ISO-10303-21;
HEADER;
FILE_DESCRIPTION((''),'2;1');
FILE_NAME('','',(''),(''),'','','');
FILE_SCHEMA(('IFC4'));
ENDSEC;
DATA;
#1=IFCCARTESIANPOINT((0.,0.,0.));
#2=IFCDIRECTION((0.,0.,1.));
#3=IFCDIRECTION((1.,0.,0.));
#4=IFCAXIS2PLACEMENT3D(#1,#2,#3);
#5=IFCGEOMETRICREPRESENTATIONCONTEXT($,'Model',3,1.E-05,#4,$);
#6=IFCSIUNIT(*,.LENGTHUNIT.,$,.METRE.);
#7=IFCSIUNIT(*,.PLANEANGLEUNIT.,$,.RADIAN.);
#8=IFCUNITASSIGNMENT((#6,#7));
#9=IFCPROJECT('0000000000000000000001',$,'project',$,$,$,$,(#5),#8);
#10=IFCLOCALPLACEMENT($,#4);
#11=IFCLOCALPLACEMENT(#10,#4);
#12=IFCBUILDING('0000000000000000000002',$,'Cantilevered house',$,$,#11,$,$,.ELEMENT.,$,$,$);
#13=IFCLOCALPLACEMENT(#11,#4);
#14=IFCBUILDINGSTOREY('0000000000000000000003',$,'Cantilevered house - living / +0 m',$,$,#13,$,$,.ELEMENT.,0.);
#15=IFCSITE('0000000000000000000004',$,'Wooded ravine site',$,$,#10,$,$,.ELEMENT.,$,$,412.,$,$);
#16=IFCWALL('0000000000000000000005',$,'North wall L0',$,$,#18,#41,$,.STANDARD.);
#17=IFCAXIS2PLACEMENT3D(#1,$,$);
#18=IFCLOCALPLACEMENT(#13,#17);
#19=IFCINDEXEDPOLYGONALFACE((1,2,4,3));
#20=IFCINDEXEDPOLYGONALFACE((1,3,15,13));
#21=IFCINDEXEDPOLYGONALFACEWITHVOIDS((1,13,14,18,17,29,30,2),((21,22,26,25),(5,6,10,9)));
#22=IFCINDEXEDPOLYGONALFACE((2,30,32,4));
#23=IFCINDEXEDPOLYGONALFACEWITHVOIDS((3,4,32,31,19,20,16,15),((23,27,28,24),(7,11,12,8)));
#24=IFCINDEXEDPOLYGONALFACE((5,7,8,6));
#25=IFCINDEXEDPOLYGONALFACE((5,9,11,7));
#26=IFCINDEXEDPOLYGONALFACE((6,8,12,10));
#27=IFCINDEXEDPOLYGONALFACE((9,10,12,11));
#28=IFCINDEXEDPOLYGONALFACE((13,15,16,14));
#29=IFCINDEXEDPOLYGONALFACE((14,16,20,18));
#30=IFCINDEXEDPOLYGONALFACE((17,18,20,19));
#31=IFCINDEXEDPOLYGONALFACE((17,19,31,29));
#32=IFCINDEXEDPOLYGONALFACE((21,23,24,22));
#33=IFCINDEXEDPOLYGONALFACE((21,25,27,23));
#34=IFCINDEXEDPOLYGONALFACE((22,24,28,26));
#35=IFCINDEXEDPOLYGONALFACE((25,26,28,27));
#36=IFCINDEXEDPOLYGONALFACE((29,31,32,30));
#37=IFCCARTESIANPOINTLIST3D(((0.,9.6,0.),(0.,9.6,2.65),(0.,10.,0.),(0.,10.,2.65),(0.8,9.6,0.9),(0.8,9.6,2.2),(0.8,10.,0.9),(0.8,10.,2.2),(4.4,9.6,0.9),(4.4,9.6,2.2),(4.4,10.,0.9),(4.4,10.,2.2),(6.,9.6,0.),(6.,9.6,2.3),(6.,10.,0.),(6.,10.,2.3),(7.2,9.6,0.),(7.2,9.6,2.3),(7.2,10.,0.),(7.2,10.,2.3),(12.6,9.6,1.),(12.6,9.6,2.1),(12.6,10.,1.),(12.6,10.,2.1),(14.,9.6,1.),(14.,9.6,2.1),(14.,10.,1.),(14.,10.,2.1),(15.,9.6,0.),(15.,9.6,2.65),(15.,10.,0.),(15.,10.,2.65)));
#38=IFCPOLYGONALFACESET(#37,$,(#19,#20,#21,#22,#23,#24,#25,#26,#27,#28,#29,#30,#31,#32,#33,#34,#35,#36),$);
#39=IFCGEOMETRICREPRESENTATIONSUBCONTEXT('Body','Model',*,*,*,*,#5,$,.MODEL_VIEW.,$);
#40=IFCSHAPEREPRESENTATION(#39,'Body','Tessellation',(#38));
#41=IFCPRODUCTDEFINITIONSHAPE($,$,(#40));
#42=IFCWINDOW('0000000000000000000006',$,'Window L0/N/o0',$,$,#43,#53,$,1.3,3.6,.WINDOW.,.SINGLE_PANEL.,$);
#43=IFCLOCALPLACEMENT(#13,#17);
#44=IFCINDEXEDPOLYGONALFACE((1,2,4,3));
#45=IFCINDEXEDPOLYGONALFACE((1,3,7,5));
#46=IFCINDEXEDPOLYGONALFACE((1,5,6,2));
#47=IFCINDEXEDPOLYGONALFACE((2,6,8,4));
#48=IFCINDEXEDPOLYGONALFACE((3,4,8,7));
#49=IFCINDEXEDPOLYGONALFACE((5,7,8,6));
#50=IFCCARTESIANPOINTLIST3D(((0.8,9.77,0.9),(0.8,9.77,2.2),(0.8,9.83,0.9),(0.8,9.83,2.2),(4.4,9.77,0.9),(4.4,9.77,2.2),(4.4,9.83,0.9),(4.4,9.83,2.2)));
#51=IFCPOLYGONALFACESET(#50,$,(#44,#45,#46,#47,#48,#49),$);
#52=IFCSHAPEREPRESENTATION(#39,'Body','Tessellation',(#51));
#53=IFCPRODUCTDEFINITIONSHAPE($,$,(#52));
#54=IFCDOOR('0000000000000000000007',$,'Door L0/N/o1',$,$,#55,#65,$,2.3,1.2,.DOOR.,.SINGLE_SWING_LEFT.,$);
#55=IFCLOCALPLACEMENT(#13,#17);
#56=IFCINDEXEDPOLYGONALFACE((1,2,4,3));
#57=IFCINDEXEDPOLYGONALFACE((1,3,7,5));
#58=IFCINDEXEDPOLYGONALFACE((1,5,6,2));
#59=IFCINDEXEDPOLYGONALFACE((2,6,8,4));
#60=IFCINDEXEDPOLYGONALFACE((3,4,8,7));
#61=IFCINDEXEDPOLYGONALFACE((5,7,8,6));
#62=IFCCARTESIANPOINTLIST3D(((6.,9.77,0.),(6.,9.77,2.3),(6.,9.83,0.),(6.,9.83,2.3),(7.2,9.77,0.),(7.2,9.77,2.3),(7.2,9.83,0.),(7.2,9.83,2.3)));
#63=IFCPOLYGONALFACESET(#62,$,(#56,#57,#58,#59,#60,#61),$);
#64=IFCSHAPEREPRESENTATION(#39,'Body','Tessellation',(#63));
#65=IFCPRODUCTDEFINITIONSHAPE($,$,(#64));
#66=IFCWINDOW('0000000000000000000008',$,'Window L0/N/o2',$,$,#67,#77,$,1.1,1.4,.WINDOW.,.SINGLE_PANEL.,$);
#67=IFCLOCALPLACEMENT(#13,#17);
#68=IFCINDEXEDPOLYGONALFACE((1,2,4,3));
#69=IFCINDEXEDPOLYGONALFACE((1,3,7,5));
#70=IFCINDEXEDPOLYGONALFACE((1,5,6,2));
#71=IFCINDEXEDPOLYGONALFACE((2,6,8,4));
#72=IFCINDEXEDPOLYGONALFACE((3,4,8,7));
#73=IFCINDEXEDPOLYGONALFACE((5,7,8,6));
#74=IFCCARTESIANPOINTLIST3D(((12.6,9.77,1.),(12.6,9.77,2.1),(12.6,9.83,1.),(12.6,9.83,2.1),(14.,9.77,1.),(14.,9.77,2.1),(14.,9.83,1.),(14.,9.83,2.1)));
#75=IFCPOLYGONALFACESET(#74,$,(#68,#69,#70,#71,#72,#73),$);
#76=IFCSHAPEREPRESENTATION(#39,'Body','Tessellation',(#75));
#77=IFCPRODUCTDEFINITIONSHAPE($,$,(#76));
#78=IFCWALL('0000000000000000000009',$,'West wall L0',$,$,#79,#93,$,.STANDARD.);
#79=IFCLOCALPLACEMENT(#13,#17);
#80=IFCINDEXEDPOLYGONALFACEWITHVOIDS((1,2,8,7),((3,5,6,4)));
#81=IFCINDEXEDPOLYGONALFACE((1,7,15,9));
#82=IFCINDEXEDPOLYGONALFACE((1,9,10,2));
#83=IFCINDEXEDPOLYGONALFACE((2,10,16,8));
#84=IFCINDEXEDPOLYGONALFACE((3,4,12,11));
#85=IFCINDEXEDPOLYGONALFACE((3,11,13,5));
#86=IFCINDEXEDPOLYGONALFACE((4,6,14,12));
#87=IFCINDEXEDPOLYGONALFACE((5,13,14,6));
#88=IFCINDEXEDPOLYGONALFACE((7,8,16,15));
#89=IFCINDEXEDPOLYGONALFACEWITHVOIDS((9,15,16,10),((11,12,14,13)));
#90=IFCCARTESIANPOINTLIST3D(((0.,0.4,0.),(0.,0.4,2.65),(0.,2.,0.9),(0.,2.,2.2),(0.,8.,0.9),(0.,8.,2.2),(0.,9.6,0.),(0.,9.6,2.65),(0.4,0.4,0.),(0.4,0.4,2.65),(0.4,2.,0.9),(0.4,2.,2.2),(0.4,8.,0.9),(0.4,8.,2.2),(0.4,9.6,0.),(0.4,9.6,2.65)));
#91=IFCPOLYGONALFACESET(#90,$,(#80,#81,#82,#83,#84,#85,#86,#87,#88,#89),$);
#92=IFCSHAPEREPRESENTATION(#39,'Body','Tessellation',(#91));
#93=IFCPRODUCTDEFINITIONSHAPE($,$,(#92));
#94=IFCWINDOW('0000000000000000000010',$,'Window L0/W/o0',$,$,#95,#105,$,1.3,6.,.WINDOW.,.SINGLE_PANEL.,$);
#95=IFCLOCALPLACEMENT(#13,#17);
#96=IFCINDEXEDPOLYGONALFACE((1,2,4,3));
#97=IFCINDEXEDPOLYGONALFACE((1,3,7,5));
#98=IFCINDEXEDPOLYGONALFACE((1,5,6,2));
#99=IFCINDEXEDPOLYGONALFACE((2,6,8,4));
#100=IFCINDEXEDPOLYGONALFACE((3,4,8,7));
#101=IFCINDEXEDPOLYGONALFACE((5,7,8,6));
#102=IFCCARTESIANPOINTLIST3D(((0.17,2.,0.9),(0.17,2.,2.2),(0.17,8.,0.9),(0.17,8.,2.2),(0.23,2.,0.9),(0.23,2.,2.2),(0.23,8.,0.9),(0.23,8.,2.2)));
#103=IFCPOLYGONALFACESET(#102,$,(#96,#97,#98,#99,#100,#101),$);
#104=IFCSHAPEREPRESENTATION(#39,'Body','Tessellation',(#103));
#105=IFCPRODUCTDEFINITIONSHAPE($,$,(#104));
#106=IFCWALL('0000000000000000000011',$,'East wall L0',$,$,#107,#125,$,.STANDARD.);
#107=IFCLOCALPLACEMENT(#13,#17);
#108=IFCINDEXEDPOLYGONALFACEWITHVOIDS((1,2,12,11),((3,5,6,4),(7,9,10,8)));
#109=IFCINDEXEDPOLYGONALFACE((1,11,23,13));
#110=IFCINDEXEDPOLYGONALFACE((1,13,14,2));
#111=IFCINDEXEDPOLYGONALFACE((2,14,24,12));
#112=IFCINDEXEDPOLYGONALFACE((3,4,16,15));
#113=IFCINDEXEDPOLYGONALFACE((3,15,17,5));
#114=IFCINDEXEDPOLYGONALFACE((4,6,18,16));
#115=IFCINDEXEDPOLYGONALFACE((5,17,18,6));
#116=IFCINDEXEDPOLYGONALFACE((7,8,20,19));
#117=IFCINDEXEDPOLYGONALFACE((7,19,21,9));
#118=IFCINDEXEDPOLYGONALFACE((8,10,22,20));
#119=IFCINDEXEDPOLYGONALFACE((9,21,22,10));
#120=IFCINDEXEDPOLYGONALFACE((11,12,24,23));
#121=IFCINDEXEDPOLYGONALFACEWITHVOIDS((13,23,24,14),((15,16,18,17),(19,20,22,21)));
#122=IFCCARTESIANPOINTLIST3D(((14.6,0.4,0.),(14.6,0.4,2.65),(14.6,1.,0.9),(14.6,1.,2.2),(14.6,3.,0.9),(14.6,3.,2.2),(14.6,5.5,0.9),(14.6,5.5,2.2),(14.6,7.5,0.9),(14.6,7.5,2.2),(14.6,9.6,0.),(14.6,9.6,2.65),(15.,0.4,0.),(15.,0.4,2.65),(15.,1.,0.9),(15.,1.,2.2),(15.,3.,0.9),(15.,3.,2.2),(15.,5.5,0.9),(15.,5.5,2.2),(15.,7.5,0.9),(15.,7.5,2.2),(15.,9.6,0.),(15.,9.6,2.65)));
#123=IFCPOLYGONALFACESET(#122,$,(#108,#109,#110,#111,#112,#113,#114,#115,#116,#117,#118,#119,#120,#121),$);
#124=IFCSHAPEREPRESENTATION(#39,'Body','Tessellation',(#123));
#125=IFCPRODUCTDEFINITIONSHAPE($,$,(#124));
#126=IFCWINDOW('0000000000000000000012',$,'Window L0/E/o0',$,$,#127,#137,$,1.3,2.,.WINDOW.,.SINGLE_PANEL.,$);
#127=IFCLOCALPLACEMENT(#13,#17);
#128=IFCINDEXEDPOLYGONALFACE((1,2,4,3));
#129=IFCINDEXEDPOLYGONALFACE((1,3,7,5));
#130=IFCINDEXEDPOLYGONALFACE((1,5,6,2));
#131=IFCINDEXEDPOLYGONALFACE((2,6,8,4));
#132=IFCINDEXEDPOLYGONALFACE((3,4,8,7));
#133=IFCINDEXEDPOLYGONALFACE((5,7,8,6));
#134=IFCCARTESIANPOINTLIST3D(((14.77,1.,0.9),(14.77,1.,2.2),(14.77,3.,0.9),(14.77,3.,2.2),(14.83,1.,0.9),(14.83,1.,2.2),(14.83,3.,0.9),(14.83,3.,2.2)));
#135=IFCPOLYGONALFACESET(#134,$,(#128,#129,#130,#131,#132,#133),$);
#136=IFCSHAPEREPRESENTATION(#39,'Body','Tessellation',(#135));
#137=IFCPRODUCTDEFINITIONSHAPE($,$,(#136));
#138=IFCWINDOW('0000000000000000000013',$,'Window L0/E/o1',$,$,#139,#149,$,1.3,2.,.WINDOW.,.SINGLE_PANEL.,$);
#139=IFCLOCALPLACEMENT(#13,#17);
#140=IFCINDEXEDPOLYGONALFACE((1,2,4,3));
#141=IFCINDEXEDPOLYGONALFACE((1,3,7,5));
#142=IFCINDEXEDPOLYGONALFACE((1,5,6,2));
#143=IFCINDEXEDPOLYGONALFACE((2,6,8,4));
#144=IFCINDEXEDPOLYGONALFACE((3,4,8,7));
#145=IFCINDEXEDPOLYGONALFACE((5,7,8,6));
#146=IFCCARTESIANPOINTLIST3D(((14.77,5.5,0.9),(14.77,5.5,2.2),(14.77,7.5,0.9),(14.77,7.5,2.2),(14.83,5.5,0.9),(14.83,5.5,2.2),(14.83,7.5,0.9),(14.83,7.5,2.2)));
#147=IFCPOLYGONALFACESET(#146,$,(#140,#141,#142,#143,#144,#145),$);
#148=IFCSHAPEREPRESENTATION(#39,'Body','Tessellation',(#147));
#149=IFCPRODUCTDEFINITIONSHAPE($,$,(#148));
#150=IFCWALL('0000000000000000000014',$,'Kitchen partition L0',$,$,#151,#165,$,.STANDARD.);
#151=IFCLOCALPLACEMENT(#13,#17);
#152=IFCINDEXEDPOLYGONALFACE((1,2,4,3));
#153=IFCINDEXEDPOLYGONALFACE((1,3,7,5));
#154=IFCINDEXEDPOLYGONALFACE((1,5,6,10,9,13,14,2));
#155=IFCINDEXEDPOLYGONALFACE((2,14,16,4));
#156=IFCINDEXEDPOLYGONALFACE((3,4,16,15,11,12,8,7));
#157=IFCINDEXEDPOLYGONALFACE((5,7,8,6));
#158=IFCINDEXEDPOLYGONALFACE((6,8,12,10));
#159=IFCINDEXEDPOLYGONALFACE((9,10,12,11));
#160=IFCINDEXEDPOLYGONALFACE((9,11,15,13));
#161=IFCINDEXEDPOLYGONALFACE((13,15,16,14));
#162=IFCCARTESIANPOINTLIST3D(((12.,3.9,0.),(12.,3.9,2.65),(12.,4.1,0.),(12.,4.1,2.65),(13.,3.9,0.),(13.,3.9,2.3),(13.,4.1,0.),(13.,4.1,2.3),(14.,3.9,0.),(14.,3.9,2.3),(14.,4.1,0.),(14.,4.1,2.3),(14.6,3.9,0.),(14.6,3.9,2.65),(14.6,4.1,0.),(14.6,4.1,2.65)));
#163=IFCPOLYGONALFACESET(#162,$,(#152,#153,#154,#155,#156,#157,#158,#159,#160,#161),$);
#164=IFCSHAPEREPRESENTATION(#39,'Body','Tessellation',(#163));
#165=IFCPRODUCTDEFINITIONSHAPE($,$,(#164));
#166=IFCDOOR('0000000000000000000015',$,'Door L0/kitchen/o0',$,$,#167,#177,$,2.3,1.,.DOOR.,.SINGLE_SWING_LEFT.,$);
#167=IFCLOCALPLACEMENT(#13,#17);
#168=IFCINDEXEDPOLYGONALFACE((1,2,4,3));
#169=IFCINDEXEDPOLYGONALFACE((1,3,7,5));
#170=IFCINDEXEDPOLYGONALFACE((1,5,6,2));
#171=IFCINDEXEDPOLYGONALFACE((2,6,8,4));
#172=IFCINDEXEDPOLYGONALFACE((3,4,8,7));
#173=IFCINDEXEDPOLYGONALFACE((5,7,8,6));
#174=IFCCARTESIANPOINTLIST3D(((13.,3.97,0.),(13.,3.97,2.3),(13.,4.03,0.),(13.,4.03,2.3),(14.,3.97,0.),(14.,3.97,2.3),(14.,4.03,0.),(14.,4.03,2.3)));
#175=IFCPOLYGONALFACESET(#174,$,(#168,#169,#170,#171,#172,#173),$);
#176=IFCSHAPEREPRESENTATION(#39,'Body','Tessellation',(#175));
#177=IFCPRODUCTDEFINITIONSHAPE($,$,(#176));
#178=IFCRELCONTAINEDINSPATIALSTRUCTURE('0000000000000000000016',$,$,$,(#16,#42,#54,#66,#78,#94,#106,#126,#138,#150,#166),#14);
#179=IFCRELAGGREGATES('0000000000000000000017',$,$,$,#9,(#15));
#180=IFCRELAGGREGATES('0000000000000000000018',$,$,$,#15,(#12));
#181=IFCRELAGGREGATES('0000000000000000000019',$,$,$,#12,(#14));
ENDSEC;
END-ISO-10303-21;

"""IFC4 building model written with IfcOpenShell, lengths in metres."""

from ifc_helpers import new_model, si_unit, frame, frame_2d, origin_with_axes, place, context, subcontext, project, spatial, rectangle, extrude, element, fill, save


model = new_model("IFC4")

# Units and contexts
model_context = context("Model", 3, precision=1e-05, world=origin_with_axes())
body_context = subcontext(model_context, "Body", "Model", "MODEL_VIEW")
ifc_project = project(units=[si_unit("LENGTHUNIT", "METRE"), si_unit("PLANEANGLEUNIT", "RADIAN")], contexts=[model_context])

# Site, building, storey
site_placement = place(None, origin_with_axes())
site = spatial("IfcSite", under=ifc_project, at=site_placement, Name="Wooded ravine site", CompositionType="ELEMENT", RefElevation=412.0)
building_placement = place(site_placement, origin_with_axes())
building = spatial("IfcBuilding", under=site, at=building_placement, Name="Cantilevered house", CompositionType="ELEMENT")
storey_placement = place(building_placement, origin_with_axes())
storey = spatial("IfcBuildingStorey", under=building, at=storey_placement, Name="Cantilevered house - living / +0 m", CompositionType="ELEMENT", Elevation=0.0)

# Wall, openings, windows, door
wall_1_placement = place(storey_placement, origin_with_axes())
wall_1 = element("IfcWall", 1, at=wall_1_placement, inside=storey, Name="North wall L0", PredefinedType="STANDARD", context=body_context, shape_type="SweptSolid", body=[
    extrude(rectangle(XDim=15.0, YDim=0.4, at=frame_2d((7.5, 9.8))), origin_with_axes(), (0.0, 0.0, 1.0), 2.65),
])
opening_1_placement = place(storey_placement, origin_with_axes())
opening_1 = element("IfcOpeningElement", 2, at=opening_1_placement, inside=storey, cuts=wall_1, PredefinedType="OPENING", context=body_context, shape_type="SweptSolid", body=[
    extrude(rectangle(XDim=3.6, YDim=0.44, at=frame_2d((2.6, 9.8))), frame((0.0, 0.0, 0.9), z_axis=(0.0, 0.0, 1.0), x_axis=(1.0, 0.0, 0.0)), (0.0, 0.0, 1.0), 1.3),
])
opening_2_placement = place(storey_placement, origin_with_axes())
opening_2 = element("IfcOpeningElement", 3, at=opening_2_placement, inside=storey, cuts=wall_1, PredefinedType="OPENING", context=body_context, shape_type="SweptSolid", body=[
    extrude(rectangle(XDim=1.2, YDim=0.44, at=frame_2d((6.6, 9.8))), origin_with_axes(), (0.0, 0.0, 1.0), 2.3),
])
opening_3_placement = place(storey_placement, origin_with_axes())
opening_3 = element("IfcOpeningElement", 4, at=opening_3_placement, inside=storey, cuts=wall_1, PredefinedType="OPENING", context=body_context, shape_type="SweptSolid", body=[
    extrude(rectangle(XDim=1.4, YDim=0.44, at=frame_2d((13.3, 9.8))), frame((0.0, 0.0, 1.0), z_axis=(0.0, 0.0, 1.0), x_axis=(1.0, 0.0, 0.0)), (0.0, 0.0, 1.0), 1.1),
])
window_1_placement = place(storey_placement, origin_with_axes())
window_1 = element("IfcWindow", 5, at=window_1_placement, inside=storey, Name="Window L0/N/o0", OverallHeight=1.3, OverallWidth=3.6, PartitioningType="SINGLE_PANEL", PredefinedType="WINDOW", context=body_context, shape_type="SweptSolid", body=[
    extrude(rectangle(XDim=3.6, YDim=0.06, at=frame_2d((2.6, 9.8))), frame((0.0, 0.0, 0.9), z_axis=(0.0, 0.0, 1.0), x_axis=(1.0, 0.0, 0.0)), (0.0, 0.0, 1.0), 1.3),
])
fill(opening_1, window_1)
door_1_placement = place(storey_placement, origin_with_axes())
door_1 = element("IfcDoor", 6, at=door_1_placement, inside=storey, Name="Door L0/N/o1", OperationType="SINGLE_SWING_LEFT", OverallHeight=2.3, OverallWidth=1.2, PredefinedType="DOOR", context=body_context, shape_type="SweptSolid", body=[
    extrude(rectangle(XDim=1.2, YDim=0.06, at=frame_2d((6.6, 9.8))), origin_with_axes(), (0.0, 0.0, 1.0), 2.3),
])
fill(opening_2, door_1)
window_2_placement = place(storey_placement, origin_with_axes())
window_2 = element("IfcWindow", 7, at=window_2_placement, inside=storey, Name="Window L0/N/o2", OverallHeight=1.1, OverallWidth=1.4, PartitioningType="SINGLE_PANEL", PredefinedType="WINDOW", context=body_context, shape_type="SweptSolid", body=[
    extrude(rectangle(XDim=1.4, YDim=0.06, at=frame_2d((13.3, 9.8))), frame((0.0, 0.0, 1.0), z_axis=(0.0, 0.0, 1.0), x_axis=(1.0, 0.0, 0.0)), (0.0, 0.0, 1.0), 1.1),
])
fill(opening_3, window_2)

# Wall, opening, window
wall_2_placement = place(storey_placement, origin_with_axes())
wall_2 = element("IfcWall", 8, at=wall_2_placement, inside=storey, Name="West wall L0", PredefinedType="STANDARD", context=body_context, shape_type="SweptSolid", body=[
    extrude(rectangle(XDim=0.4, YDim=9.2, at=frame_2d((0.2, 5.0))), origin_with_axes(), (0.0, 0.0, 1.0), 2.65),
])
opening_4_placement = place(storey_placement, origin_with_axes())
opening_4 = element("IfcOpeningElement", 9, at=opening_4_placement, inside=storey, cuts=wall_2, PredefinedType="OPENING", context=body_context, shape_type="SweptSolid", body=[
    extrude(rectangle(XDim=0.44, YDim=6.0, at=frame_2d((0.2, 5.0))), frame((0.0, 0.0, 0.9), z_axis=(0.0, 0.0, 1.0), x_axis=(1.0, 0.0, 0.0)), (0.0, 0.0, 1.0), 1.3),
])
window_3_placement = place(storey_placement, origin_with_axes())
window_3 = element("IfcWindow", 10, at=window_3_placement, inside=storey, Name="Window L0/W/o0", OverallHeight=1.3, OverallWidth=6.0, PartitioningType="SINGLE_PANEL", PredefinedType="WINDOW", context=body_context, shape_type="SweptSolid", body=[
    extrude(rectangle(XDim=0.06, YDim=6.0, at=frame_2d((0.2, 5.0))), frame((0.0, 0.0, 0.9), z_axis=(0.0, 0.0, 1.0), x_axis=(1.0, 0.0, 0.0)), (0.0, 0.0, 1.0), 1.3),
])
fill(opening_4, window_3)

# Wall, openings, windows
wall_3_placement = place(storey_placement, origin_with_axes())
wall_3 = element("IfcWall", 11, at=wall_3_placement, inside=storey, Name="East wall L0", PredefinedType="STANDARD", context=body_context, shape_type="SweptSolid", body=[
    extrude(rectangle(XDim=0.4, YDim=9.2, at=frame_2d((14.8, 5.0))), origin_with_axes(), (0.0, 0.0, 1.0), 2.65),
])
opening_5_placement = place(storey_placement, origin_with_axes())
opening_5 = element("IfcOpeningElement", 12, at=opening_5_placement, inside=storey, cuts=wall_3, PredefinedType="OPENING", context=body_context, shape_type="SweptSolid", body=[
    extrude(rectangle(XDim=0.44, YDim=2.0, at=frame_2d((14.8, 2.0))), frame((0.0, 0.0, 0.9), z_axis=(0.0, 0.0, 1.0), x_axis=(1.0, 0.0, 0.0)), (0.0, 0.0, 1.0), 1.3),
])
opening_6_placement = place(storey_placement, origin_with_axes())
opening_6 = element("IfcOpeningElement", 13, at=opening_6_placement, inside=storey, cuts=wall_3, PredefinedType="OPENING", context=body_context, shape_type="SweptSolid", body=[
    extrude(rectangle(XDim=0.44, YDim=2.0, at=frame_2d((14.8, 6.5))), frame((0.0, 0.0, 0.9), z_axis=(0.0, 0.0, 1.0), x_axis=(1.0, 0.0, 0.0)), (0.0, 0.0, 1.0), 1.3),
])
window_4_placement = place(storey_placement, origin_with_axes())
window_4 = element("IfcWindow", 14, at=window_4_placement, inside=storey, Name="Window L0/E/o0", OverallHeight=1.3, OverallWidth=2.0, PartitioningType="SINGLE_PANEL", PredefinedType="WINDOW", context=body_context, shape_type="SweptSolid", body=[
    extrude(rectangle(XDim=0.06, YDim=2.0, at=frame_2d((14.8, 2.0))), frame((0.0, 0.0, 0.9), z_axis=(0.0, 0.0, 1.0), x_axis=(1.0, 0.0, 0.0)), (0.0, 0.0, 1.0), 1.3),
])
fill(opening_5, window_4)
window_5_placement = place(storey_placement, origin_with_axes())
window_5 = element("IfcWindow", 15, at=window_5_placement, inside=storey, Name="Window L0/E/o1", OverallHeight=1.3, OverallWidth=2.0, PartitioningType="SINGLE_PANEL", PredefinedType="WINDOW", context=body_context, shape_type="SweptSolid", body=[
    extrude(rectangle(XDim=0.06, YDim=2.0, at=frame_2d((14.8, 6.5))), frame((0.0, 0.0, 0.9), z_axis=(0.0, 0.0, 1.0), x_axis=(1.0, 0.0, 0.0)), (0.0, 0.0, 1.0), 1.3),
])
fill(opening_6, window_5)

# Wall, opening, door
wall_4_placement = place(storey_placement, origin_with_axes())
wall_4 = element("IfcWall", 16, at=wall_4_placement, inside=storey, Name="Kitchen partition L0", PredefinedType="STANDARD", context=body_context, shape_type="SweptSolid", body=[
    extrude(rectangle(XDim=2.6, YDim=0.2, at=frame_2d((13.3, 4.0))), origin_with_axes(), (0.0, 0.0, 1.0), 2.65),
])
opening_7_placement = place(storey_placement, origin_with_axes())
opening_7 = element("IfcOpeningElement", 17, at=opening_7_placement, inside=storey, cuts=wall_4, PredefinedType="OPENING", context=body_context, shape_type="SweptSolid", body=[
    extrude(rectangle(XDim=1.0, YDim=0.24, at=frame_2d((13.5, 4.0))), origin_with_axes(), (0.0, 0.0, 1.0), 2.3),
])
door_2_placement = place(storey_placement, origin_with_axes())
door_2 = element("IfcDoor", 18, at=door_2_placement, inside=storey, Name="Door L0/kitchen/o0", OperationType="SINGLE_SWING_LEFT", OverallHeight=2.3, OverallWidth=1.0, PredefinedType="DOOR", context=body_context, shape_type="SweptSolid", body=[
    extrude(rectangle(XDim=1.0, YDim=0.06, at=frame_2d((13.5, 4.0))), origin_with_axes(), (0.0, 0.0, 1.0), 2.3),
])
fill(opening_7, door_2)

save(model, "model.ifc")
